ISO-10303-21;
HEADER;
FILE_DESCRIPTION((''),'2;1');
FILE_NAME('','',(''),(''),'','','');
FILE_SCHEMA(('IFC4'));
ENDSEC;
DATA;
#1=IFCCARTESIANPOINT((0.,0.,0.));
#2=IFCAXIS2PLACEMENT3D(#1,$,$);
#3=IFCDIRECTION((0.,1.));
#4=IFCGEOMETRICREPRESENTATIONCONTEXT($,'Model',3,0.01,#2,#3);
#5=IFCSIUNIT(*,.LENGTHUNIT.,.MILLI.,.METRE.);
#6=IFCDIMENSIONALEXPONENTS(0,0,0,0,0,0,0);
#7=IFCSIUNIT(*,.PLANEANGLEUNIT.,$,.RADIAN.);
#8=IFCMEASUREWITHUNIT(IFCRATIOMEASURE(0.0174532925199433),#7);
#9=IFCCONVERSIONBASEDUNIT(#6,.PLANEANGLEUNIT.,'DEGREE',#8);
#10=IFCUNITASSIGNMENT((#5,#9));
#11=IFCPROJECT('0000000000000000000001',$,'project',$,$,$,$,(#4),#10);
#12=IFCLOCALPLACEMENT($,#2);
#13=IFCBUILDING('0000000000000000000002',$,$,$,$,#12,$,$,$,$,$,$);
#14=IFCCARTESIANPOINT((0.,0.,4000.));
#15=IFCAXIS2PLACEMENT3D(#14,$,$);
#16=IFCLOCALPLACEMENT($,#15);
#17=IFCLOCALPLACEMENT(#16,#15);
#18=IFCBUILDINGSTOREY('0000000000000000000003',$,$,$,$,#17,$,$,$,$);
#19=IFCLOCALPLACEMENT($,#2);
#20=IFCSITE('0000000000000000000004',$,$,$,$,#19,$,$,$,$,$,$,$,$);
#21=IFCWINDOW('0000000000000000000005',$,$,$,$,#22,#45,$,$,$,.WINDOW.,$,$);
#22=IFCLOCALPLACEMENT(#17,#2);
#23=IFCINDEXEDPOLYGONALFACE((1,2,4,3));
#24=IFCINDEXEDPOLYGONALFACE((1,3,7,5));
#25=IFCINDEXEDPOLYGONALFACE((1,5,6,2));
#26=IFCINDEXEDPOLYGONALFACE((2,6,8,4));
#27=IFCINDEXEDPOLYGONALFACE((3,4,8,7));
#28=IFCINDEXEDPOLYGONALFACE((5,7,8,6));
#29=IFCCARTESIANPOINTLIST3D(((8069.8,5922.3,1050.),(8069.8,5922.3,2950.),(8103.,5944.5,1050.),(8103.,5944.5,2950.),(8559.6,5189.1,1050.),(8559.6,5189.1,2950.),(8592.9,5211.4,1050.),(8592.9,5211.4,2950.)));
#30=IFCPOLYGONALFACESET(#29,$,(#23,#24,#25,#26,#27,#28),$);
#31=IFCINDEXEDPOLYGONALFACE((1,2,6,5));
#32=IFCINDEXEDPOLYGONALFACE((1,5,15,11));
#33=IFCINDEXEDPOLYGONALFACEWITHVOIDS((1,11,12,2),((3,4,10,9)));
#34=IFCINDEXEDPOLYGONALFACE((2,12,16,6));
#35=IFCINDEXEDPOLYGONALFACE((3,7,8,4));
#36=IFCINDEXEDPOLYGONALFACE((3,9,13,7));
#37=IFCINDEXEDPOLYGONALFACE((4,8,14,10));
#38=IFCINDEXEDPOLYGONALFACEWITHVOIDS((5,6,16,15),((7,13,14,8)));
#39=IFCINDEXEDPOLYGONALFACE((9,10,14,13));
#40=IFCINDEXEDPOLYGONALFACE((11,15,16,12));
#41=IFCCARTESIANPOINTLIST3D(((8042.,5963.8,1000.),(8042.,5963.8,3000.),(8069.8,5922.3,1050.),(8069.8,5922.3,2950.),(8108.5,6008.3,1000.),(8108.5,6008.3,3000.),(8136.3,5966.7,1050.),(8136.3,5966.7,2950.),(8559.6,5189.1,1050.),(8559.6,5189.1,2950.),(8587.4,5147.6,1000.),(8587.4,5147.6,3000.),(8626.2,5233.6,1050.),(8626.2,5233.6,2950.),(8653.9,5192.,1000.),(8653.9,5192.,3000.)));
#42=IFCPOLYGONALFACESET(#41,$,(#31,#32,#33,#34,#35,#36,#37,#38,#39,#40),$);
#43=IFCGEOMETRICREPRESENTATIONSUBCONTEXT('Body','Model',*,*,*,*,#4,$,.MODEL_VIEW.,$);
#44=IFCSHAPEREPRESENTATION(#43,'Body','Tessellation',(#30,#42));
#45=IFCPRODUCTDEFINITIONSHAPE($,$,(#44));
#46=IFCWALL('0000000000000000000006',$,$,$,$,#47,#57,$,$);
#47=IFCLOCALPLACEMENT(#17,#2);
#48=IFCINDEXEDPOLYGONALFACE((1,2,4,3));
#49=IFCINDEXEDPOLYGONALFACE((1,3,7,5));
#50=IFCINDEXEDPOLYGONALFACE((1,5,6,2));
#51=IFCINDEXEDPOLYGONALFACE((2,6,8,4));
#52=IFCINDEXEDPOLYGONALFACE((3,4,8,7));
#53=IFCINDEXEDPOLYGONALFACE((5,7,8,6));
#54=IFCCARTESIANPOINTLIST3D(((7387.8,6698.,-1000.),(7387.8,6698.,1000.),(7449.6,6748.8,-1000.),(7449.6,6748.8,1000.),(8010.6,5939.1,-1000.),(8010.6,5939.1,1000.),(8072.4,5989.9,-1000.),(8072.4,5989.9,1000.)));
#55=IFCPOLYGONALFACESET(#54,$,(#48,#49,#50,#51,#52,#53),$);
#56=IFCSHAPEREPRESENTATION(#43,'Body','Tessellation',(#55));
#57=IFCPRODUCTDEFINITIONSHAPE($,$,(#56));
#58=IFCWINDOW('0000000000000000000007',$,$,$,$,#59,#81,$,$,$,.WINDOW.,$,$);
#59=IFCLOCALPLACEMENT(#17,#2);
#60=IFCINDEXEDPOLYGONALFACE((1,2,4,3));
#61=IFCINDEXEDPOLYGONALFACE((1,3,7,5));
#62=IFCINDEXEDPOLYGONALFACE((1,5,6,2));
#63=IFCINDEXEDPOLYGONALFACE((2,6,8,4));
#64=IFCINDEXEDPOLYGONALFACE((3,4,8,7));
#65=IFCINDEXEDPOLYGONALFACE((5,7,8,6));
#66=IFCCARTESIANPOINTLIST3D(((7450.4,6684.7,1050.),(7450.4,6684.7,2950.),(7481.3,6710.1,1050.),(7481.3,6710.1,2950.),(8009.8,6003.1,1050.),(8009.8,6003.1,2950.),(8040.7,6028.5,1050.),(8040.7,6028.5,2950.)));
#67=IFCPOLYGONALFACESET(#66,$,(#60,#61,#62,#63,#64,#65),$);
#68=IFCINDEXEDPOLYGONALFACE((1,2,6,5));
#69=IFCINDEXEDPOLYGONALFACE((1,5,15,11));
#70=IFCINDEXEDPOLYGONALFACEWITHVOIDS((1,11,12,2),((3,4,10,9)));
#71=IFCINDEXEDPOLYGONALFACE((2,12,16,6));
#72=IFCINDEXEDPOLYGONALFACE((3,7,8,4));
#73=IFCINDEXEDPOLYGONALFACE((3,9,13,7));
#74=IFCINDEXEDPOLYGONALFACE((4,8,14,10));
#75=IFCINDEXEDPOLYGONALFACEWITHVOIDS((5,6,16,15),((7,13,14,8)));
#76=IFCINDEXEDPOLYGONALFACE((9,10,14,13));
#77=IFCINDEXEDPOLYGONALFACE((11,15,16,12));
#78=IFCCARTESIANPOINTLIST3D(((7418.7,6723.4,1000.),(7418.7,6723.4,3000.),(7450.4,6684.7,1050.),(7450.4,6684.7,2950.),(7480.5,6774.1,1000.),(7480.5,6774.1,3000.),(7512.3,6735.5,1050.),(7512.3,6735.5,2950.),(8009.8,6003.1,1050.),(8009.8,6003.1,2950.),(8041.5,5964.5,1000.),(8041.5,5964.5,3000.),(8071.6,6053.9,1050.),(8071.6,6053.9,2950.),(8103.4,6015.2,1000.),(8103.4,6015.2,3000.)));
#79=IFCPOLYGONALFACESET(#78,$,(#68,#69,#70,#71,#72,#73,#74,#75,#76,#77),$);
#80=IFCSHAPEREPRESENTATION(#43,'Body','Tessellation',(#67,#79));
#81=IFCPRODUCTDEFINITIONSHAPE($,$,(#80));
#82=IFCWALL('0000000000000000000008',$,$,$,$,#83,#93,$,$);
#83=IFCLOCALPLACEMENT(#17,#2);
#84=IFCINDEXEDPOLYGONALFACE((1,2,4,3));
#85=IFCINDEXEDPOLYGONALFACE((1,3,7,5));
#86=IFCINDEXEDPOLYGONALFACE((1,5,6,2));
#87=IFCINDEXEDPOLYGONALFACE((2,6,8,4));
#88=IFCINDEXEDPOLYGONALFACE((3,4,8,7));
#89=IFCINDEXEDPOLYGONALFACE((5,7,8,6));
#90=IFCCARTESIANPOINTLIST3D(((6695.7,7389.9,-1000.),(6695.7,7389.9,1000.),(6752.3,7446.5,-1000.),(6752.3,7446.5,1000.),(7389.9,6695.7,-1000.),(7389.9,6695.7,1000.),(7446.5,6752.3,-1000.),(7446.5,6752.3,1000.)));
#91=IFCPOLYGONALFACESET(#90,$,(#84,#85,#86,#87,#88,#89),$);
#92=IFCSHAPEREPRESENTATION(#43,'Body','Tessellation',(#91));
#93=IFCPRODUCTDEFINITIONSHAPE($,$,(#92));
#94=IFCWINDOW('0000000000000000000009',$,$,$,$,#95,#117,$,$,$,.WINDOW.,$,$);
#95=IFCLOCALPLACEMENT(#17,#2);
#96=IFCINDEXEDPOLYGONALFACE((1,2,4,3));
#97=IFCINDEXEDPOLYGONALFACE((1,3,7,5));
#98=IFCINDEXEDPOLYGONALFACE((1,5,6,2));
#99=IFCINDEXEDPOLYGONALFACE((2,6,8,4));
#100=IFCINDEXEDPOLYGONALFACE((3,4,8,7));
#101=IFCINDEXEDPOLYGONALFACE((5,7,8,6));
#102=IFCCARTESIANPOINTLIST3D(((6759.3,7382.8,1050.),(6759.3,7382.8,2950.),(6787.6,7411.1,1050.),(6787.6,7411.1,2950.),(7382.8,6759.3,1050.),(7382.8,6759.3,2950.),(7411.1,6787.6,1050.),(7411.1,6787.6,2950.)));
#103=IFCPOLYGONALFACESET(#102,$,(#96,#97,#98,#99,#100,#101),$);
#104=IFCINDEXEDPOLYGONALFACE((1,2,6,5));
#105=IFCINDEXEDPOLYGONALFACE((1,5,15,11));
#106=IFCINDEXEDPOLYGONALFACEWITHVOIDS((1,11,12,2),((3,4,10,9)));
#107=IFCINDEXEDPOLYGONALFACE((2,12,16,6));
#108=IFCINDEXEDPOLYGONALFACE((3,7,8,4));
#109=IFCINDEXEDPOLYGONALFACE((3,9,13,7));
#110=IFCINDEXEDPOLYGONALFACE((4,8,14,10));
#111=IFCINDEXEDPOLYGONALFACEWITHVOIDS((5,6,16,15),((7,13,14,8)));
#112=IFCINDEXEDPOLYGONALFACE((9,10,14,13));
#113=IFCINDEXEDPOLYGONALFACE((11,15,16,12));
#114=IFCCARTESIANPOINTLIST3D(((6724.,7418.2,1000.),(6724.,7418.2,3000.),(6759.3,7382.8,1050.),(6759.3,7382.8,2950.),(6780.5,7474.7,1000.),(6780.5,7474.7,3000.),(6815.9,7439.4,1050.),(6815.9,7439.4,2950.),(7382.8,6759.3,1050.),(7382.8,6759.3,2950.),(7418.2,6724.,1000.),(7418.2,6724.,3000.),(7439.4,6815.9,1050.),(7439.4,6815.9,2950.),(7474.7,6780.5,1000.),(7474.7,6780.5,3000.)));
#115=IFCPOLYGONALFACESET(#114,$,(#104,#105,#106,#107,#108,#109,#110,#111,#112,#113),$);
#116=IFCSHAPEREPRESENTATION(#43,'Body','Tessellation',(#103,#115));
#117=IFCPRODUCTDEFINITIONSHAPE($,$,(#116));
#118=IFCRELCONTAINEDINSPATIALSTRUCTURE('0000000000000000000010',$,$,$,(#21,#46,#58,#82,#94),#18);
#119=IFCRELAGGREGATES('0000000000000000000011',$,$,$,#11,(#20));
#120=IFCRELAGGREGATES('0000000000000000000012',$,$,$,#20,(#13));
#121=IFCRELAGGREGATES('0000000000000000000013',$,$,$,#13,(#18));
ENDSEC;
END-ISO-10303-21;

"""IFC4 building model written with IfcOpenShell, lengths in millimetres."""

from ifc_helpers import new_model, entity, si_unit, converted_unit, direction, frame, origin, origin_2d, place, context, subcontext, project, spatial, rectangle, extrude, element, save


model = new_model("IFC4")

# Units and contexts
model_context = context("Model", 3, precision=0.01, world=origin(), true_north=direction((0.0, 1.0)))
body_context = subcontext(model_context, "Body", "Model", "MODEL_VIEW")
ifc_project = project(units=[si_unit("LENGTHUNIT", "METRE", prefix="MILLI"), converted_unit("PLANEANGLEUNIT", "DEGREE", entity("IfcRatioMeasure", 0.0174532925199433), si_unit("PLANEANGLEUNIT", "RADIAN"), dimensions=[0, 0, 0, 0, 0, 0, 0])], contexts=[model_context])

# Site, building, storey
site_placement = place(None, origin())
site = spatial("IfcSite", under=ifc_project, at=site_placement)
building_placement = place(None, origin())
building = spatial("IfcBuilding", under=site, at=building_placement)
placement = place(None, frame((0.0, 0.0, 4000.0)))
storey_placement = place(placement, frame((0.0, 0.0, 4000.0)))
storey = spatial("IfcBuildingStorey", under=building, at=storey_placement)

# Shared definitions
cartesian_point_1 = entity("IfcCartesianPoint", [-440.9, -950.0])
shared_polyline = entity("IfcPolyline", [cartesian_point_1, entity("IfcCartesianPoint", [-440.9, 950.0]), entity("IfcCartesianPoint", [-440.9, 950.0]), entity("IfcCartesianPoint", [440.9, 950.0]), entity("IfcCartesianPoint", [440.9, 950.0]), entity("IfcCartesianPoint", [440.9, -950.0]), entity("IfcCartesianPoint", [440.9, -950.0]), entity("IfcCartesianPoint", [-440.9, -950.0]), cartesian_point_1])

# Window
window_1_placement = place(storey_placement, frame((8314.7, 5555.7, 2000.0), z_axis=(0.0, 0.0, 1.0), x_axis=(-5555.702343, 8314.696115, 0.0)))
cartesian_point_2 = entity("IfcCartesianPoint", [-490.9, -1000.0])
element("IfcWindow", 1, at=window_1_placement, inside=storey, PredefinedType="WINDOW", context=body_context, shape_type="SweptSolid", body=[
    entity("IfcExtrudedAreaSolid", entity("IfcArbitraryClosedProfileDef", "AREA", None, shared_polyline), entity("IfcAxis2Placement3D", entity("IfcCartesianPoint", [0.0, 0.0, 0.0]), entity("IfcDirection", [0.0, -1.0, 0.0]), entity("IfcDirection", [1.0, 0.0, 0.0])), entity("IfcDirection", [0.0, 0.0, 1.0]), 40.0),
    entity("IfcExtrudedAreaSolid", entity("IfcArbitraryProfileDefWithVoids", "AREA", None, entity("IfcPolyline", [cartesian_point_2, entity("IfcCartesianPoint", [-490.9, 1000.0]), entity("IfcCartesianPoint", [-490.9, 1000.0]), entity("IfcCartesianPoint", [490.9, 1000.0]), entity("IfcCartesianPoint", [490.9, 1000.0]), entity("IfcCartesianPoint", [490.9, -1000.0]), entity("IfcCartesianPoint", [490.9, -1000.0]), entity("IfcCartesianPoint", [-490.9, -1000.0]), cartesian_point_2]), [shared_polyline]), entity("IfcAxis2Placement3D", entity("IfcCartesianPoint", [0.0, 0.0, 0.0]), entity("IfcDirection", [0.0, -1.0, 0.0]), entity("IfcDirection", [1.0, 0.0, 0.0])), entity("IfcDirection", [0.0, 0.0, 1.0]), 80.0),
])

# Wall
wall_1_placement = place(storey_placement, frame((7730.1, 6343.9, -1000.0), z_axis=(0.0, 0.0, 1.0), x_axis=(-6343.932701, 7730.104649, 0.0)))
element("IfcWall", 2, at=wall_1_placement, inside=storey, context=body_context, shape_type="SweptSolid", body=[
    extrude(rectangle(XDim=981.7, YDim=80.0, at=origin_2d()), origin(), (0.0, 0.0, 1.0), 2000.0),
])

# Window
window_2_placement = place(storey_placement, frame((7730.1, 6343.9, 2000.0), z_axis=(0.0, 0.0, 1.0), x_axis=(-6343.932701, 7730.104649, 0.0)))
cartesian_point_3 = entity("IfcCartesianPoint", [-490.9, -1000.0])
element("IfcWindow", 3, at=window_2_placement, inside=storey, PredefinedType="WINDOW", context=body_context, shape_type="SweptSolid", body=[
    entity("IfcExtrudedAreaSolid", entity("IfcArbitraryClosedProfileDef", "AREA", None, shared_polyline), entity("IfcAxis2Placement3D", entity("IfcCartesianPoint", [0.0, 0.0, 0.0]), entity("IfcDirection", [0.0, -1.0, 0.0]), entity("IfcDirection", [1.0, 0.0, 0.0])), entity("IfcDirection", [0.0, 0.0, 1.0]), 40.0),
    entity("IfcExtrudedAreaSolid", entity("IfcArbitraryProfileDefWithVoids", "AREA", None, entity("IfcPolyline", [cartesian_point_3, entity("IfcCartesianPoint", [-490.9, 1000.0]), entity("IfcCartesianPoint", [-490.9, 1000.0]), entity("IfcCartesianPoint", [490.9, 1000.0]), entity("IfcCartesianPoint", [490.9, 1000.0]), entity("IfcCartesianPoint", [490.9, -1000.0]), entity("IfcCartesianPoint", [490.9, -1000.0]), entity("IfcCartesianPoint", [-490.9, -1000.0]), cartesian_point_3]), [shared_polyline]), entity("IfcAxis2Placement3D", entity("IfcCartesianPoint", [0.0, 0.0, 0.0]), entity("IfcDirection", [0.0, -1.0, 0.0]), entity("IfcDirection", [1.0, 0.0, 0.0])), entity("IfcDirection", [0.0, 0.0, 1.0]), 80.0),
])

# Wall
wall_2_placement = place(storey_placement, frame((7071.1, 7071.1, -1000.0), z_axis=(0.0, 0.0, 1.0), x_axis=(-7071.067966, 7071.067657, 0.0)))
element("IfcWall", 4, at=wall_2_placement, inside=storey, context=body_context, shape_type="SweptSolid", body=[
    extrude(rectangle(XDim=981.7, YDim=80.0, at=origin_2d()), origin(), (0.0, 0.0, 1.0), 2000.0),
])

# Window
window_3_placement = place(storey_placement, frame((7071.1, 7071.1, 2000.0), z_axis=(0.0, 0.0, 1.0), x_axis=(-7071.067966, 7071.067657, 0.0)))
cartesian_point_4 = entity("IfcCartesianPoint", [-490.9, -1000.0])
element("IfcWindow", 5, at=window_3_placement, inside=storey, PredefinedType="WINDOW", context=body_context, shape_type="SweptSolid", body=[
    entity("IfcExtrudedAreaSolid", entity("IfcArbitraryClosedProfileDef", "AREA", None, shared_polyline), entity("IfcAxis2Placement3D", entity("IfcCartesianPoint", [0.0, 0.0, 0.0]), entity("IfcDirection", [0.0, -1.0, 0.0]), entity("IfcDirection", [1.0, 0.0, 0.0])), entity("IfcDirection", [0.0, 0.0, 1.0]), 40.0),
    entity("IfcExtrudedAreaSolid", entity("IfcArbitraryProfileDefWithVoids", "AREA", None, entity("IfcPolyline", [cartesian_point_4, entity("IfcCartesianPoint", [-490.9, 1000.0]), entity("IfcCartesianPoint", [-490.9, 1000.0]), entity("IfcCartesianPoint", [490.9, 1000.0]), entity("IfcCartesianPoint", [490.9, 1000.0]), entity("IfcCartesianPoint", [490.9, -1000.0]), entity("IfcCartesianPoint", [490.9, -1000.0]), entity("IfcCartesianPoint", [-490.9, -1000.0]), cartesian_point_4]), [shared_polyline]), entity("IfcAxis2Placement3D", entity("IfcCartesianPoint", [0.0, 0.0, 0.0]), entity("IfcDirection", [0.0, -1.0, 0.0]), entity("IfcDirection", [1.0, 0.0, 0.0])), entity("IfcDirection", [0.0, 0.0, 1.0]), 80.0),
])

save(model, "model.ifc")
